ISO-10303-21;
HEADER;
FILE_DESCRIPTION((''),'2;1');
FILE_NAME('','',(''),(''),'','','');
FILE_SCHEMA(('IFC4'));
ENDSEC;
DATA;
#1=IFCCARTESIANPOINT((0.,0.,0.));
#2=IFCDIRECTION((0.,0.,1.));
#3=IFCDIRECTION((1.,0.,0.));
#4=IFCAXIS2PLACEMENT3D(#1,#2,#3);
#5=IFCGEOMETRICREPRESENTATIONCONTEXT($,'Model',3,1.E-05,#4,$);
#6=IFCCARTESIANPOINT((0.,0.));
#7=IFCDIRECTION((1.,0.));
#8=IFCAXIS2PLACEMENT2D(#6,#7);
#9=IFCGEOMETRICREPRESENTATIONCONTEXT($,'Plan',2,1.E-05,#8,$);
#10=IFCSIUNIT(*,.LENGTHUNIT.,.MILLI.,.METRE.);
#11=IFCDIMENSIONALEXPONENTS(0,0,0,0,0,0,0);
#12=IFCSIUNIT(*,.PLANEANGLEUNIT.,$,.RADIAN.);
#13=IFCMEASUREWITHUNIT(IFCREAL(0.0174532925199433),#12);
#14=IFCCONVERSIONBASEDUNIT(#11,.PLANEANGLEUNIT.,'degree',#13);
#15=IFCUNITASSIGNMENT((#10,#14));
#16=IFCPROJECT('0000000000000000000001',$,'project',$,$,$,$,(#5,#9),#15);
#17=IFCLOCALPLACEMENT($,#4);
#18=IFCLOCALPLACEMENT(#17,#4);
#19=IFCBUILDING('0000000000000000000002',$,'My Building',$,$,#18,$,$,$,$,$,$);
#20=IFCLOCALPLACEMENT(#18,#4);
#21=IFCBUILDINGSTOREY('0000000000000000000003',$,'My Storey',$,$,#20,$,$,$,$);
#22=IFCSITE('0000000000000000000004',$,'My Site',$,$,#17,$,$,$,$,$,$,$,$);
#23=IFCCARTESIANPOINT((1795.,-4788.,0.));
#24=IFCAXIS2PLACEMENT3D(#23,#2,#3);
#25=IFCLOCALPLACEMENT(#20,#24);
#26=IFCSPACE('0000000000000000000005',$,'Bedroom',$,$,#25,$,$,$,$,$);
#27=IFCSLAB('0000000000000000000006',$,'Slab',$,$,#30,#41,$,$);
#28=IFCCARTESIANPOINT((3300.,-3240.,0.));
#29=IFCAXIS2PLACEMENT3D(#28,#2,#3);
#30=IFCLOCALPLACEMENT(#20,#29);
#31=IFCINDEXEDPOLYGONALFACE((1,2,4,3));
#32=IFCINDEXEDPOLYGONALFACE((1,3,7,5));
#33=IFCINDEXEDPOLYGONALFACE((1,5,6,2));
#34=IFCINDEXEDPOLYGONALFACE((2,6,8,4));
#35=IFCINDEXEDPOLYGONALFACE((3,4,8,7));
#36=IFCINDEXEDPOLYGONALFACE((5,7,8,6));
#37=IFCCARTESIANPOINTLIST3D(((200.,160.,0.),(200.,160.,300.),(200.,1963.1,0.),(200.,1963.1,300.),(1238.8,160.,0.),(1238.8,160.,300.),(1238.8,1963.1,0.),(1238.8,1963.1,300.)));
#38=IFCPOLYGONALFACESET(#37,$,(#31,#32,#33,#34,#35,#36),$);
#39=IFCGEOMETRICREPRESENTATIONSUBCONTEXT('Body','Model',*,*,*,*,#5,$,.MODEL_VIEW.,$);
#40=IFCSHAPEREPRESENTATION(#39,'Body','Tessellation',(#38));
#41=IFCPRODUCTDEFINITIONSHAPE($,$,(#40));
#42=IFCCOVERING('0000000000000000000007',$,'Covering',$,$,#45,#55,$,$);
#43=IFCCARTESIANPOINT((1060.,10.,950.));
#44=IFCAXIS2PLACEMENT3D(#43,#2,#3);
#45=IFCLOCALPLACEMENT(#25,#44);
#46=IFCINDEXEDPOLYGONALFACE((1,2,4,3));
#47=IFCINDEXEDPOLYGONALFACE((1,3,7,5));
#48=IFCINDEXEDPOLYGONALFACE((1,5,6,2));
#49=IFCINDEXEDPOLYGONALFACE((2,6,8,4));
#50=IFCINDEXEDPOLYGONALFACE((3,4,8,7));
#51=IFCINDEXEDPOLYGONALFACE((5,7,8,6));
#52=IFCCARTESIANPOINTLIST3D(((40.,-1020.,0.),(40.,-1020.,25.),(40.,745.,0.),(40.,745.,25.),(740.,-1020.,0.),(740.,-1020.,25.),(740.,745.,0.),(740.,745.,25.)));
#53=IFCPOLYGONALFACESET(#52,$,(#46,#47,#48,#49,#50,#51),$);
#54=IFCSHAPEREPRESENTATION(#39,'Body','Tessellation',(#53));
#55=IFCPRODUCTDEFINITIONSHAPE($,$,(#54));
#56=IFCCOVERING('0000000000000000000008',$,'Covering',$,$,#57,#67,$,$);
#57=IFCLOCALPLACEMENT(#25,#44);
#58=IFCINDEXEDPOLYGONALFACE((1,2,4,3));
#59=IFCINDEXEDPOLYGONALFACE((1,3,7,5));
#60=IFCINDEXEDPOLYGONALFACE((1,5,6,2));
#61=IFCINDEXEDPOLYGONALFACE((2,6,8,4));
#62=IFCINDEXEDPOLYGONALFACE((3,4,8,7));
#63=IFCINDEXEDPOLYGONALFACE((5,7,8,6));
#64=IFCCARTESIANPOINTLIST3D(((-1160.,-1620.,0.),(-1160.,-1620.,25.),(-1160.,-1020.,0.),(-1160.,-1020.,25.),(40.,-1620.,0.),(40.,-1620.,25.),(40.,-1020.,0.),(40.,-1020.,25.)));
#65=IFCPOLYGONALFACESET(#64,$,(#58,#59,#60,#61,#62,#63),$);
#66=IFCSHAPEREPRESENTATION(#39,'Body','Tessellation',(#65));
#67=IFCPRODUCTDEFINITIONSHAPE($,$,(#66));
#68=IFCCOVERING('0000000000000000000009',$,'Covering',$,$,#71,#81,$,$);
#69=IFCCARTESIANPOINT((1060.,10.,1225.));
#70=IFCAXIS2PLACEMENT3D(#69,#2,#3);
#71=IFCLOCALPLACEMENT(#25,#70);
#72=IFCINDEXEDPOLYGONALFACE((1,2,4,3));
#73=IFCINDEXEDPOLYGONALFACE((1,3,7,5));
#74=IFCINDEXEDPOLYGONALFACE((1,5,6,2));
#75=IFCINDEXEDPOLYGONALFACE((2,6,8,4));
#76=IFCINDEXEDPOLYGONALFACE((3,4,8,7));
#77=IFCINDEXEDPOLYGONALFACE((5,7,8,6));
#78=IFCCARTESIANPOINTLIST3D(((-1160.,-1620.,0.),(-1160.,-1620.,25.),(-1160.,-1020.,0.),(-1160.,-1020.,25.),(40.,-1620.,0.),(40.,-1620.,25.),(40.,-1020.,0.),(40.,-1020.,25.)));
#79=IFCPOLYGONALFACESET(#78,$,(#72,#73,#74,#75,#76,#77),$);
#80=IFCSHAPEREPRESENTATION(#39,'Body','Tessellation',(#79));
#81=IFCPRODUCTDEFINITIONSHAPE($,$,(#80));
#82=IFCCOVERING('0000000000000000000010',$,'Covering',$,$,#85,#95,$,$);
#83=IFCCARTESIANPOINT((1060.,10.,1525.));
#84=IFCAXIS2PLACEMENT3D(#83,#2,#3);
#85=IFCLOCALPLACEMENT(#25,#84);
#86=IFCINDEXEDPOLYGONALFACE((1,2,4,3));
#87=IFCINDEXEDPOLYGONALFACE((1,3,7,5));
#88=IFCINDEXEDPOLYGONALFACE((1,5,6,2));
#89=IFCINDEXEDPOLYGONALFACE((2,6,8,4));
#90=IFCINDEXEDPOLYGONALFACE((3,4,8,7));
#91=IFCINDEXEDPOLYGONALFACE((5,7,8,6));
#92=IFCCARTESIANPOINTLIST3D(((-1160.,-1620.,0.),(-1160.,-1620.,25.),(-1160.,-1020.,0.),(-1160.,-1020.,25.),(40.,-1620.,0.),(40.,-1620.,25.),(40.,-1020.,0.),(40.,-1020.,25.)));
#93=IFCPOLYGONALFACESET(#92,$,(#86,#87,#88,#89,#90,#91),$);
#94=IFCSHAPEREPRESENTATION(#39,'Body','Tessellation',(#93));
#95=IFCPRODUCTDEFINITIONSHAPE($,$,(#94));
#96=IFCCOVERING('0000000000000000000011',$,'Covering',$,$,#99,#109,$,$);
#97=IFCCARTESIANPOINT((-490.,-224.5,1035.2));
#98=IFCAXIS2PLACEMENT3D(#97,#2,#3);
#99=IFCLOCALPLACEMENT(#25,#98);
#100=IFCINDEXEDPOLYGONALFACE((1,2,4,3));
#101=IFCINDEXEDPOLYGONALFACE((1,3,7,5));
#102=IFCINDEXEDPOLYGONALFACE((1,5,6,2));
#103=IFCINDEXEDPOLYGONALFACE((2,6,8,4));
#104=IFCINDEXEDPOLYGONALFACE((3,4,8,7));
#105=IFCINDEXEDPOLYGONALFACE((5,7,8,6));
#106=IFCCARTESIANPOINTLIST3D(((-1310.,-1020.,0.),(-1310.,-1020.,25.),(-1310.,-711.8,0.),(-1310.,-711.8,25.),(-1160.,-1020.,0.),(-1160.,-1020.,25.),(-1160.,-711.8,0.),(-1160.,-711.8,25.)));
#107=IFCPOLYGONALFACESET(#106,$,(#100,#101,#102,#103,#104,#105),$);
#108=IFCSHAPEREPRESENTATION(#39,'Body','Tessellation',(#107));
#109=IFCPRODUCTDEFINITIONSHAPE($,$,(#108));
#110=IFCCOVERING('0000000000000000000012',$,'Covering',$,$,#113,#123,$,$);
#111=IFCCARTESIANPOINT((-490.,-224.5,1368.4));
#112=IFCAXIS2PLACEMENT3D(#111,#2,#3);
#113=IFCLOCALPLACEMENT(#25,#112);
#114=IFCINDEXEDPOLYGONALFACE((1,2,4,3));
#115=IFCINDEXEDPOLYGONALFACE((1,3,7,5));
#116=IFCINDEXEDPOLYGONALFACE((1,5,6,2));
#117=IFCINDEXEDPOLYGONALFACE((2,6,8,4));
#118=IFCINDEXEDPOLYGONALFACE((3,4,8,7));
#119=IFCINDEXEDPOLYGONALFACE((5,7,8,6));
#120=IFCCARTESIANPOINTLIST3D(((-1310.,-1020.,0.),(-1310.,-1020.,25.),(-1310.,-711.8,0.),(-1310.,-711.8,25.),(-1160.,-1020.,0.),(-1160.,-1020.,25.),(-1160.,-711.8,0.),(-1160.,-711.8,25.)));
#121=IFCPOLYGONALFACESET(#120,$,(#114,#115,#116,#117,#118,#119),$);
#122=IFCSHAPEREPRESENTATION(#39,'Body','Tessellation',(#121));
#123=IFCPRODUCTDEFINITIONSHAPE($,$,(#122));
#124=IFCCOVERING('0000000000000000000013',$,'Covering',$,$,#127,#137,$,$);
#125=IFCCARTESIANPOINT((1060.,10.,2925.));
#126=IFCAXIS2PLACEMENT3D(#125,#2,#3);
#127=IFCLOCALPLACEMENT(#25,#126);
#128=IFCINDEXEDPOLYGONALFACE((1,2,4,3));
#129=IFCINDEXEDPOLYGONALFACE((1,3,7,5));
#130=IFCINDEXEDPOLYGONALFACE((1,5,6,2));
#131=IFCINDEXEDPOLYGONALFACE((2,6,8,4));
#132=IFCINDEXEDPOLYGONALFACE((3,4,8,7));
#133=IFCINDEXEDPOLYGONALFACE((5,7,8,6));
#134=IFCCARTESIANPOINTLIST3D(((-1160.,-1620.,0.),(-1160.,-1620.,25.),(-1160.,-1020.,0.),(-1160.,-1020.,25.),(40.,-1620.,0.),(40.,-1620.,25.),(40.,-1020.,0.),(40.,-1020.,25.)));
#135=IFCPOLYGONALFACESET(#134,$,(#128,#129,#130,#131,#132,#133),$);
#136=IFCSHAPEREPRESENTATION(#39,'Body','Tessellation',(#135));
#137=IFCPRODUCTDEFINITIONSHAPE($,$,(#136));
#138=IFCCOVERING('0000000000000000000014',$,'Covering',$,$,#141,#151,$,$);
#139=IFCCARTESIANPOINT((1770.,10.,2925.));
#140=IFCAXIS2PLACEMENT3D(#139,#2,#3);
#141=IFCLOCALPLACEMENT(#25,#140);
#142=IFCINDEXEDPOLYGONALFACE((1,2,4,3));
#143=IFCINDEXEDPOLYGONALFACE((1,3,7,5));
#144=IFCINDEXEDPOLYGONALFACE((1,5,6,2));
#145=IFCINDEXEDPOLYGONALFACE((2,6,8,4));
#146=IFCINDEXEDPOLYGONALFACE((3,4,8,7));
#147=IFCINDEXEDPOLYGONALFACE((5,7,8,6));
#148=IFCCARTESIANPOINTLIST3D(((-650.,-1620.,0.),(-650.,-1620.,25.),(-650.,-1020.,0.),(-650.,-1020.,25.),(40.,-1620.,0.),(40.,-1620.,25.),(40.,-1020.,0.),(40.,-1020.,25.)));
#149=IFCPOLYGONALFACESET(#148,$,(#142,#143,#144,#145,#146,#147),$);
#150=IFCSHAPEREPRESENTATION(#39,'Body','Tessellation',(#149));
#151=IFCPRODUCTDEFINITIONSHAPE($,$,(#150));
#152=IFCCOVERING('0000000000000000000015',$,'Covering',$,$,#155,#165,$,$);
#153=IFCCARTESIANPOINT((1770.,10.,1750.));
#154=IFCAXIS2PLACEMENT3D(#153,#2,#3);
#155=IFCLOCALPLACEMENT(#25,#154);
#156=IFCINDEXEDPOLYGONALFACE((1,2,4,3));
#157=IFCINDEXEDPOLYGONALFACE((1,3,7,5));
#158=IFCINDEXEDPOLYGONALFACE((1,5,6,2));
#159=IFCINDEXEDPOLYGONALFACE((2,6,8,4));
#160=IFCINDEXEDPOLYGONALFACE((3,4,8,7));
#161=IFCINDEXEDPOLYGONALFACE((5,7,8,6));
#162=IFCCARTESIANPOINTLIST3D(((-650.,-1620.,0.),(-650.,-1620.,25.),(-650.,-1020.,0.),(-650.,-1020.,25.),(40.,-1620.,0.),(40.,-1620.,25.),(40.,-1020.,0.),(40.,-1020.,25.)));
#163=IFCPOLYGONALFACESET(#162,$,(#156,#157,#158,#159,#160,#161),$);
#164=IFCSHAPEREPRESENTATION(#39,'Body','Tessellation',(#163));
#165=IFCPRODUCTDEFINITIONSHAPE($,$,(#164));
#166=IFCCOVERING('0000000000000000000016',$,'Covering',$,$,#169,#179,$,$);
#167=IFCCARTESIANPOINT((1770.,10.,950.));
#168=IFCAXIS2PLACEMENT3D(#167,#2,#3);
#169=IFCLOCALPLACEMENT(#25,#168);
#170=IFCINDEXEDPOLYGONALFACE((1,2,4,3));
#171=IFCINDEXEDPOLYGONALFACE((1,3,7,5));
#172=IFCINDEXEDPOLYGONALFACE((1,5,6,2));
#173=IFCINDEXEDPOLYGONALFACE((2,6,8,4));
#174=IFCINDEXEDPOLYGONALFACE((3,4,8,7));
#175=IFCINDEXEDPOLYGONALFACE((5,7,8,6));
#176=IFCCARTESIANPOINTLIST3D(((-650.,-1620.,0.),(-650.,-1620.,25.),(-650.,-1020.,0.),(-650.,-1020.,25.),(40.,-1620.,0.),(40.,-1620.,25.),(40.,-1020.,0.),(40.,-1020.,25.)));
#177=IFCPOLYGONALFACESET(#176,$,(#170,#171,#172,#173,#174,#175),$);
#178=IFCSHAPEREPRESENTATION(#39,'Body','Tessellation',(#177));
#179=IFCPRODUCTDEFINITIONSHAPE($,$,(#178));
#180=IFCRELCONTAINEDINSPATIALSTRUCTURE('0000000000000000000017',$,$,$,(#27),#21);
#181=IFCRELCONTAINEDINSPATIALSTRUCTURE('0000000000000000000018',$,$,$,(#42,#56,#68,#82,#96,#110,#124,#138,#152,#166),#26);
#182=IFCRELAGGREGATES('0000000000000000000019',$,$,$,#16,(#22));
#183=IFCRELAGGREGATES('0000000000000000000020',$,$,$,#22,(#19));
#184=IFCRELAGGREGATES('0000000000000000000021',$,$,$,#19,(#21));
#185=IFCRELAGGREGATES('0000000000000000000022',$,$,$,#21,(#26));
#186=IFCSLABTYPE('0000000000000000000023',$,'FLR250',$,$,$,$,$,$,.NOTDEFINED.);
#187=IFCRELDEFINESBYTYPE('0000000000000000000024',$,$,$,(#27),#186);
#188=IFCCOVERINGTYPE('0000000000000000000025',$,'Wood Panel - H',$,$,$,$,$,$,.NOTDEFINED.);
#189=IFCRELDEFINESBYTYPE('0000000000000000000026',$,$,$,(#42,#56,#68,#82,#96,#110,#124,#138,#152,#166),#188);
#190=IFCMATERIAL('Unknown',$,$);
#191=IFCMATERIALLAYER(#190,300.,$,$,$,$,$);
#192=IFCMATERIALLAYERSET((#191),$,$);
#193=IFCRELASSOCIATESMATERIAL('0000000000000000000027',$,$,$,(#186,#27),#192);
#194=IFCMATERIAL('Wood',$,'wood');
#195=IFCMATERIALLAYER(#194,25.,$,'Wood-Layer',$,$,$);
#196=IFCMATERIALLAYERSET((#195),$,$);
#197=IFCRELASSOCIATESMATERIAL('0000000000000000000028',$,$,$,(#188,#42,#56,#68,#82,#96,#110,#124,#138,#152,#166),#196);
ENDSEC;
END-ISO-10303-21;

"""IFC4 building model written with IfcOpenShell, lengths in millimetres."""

from ifc_helpers import new_model, entity, si_unit, converted_unit, frame, origin_with_axes, origin_2d_with_axis, place, context, subcontext, project, spatial, line, indexed_curve, outline, extrude, material, layer, layer_set, layer_usage, type_object, element, save


model = new_model("IFC4")

# Units and contexts
model_context = context("Model", 3, precision=1e-05, world=origin_with_axes())
plan_context = context("Plan", 2, precision=1e-05, world=origin_2d_with_axis())
body_context_1 = subcontext(model_context, "Body", "Model", "MODEL_VIEW")
ifc_project = project(units=[si_unit("LENGTHUNIT", "METRE", prefix="MILLI"), converted_unit("PLANEANGLEUNIT", "degree", entity("IfcReal", 0.0174532925199433), si_unit("PLANEANGLEUNIT", "RADIAN"), dimensions=[0, 0, 0, 0, 0, 0, 0])], contexts=[model_context, plan_context])

# Site, building, storey
site_placement = place(None, origin_with_axes())
site = spatial("IfcSite", under=ifc_project, at=site_placement, Name="My Site")
building_placement = place(site_placement, origin_with_axes())
building = spatial("IfcBuilding", under=site, at=building_placement, Name="My Building")
storey_placement = place(building_placement, origin_with_axes())
storey = spatial("IfcBuildingStorey", under=building, at=storey_placement, Name="My Storey")

# Slab
ifc_material_1 = material(Name="Unknown")
ifc_layer_1 = layer(ifc_material_1, 300.0)
ifc_layer_set_1 = layer_set([ifc_layer_1])
ifc_layer_usage_1 = layer_usage(ifc_layer_set_1, "AXIS3", "POSITIVE", 0.0)
slab_type = type_object("IfcSlabType", Name="FLR250", PredefinedType="NOTDEFINED", material=ifc_layer_set_1)
slab_placement = place(storey_placement, frame((3300.0, -3240.0, 0.0), z_axis=(0.0, 0.0, 1.0), x_axis=(1.0, 0.0, 0.0)))
element("IfcSlab", 1, at=slab_placement, inside=storey, type_object=slab_type, material=ifc_layer_usage_1, Name="Slab", context=body_context_1, shape_type="SweptSolid", body=[
    extrude(outline(indexed_curve([(200.0, 160.0), (1238.8, 160.0), (1238.8, 1963.1), (200.0, 1963.1)], segments=[line(4, 1), line(1, 2), line(2, 3), line(3, 4)], self_intersect=False)), None, (0.0, 0.0, 1.0), 300.0),
])

# Shared definitions
space_1_placement = place(storey_placement, frame((1795.0, -4788.0, 0.0), z_axis=(0.0, 0.0, 1.0), x_axis=(1.0, 0.0, 0.0)))
space_1 = spatial("IfcSpace", under=storey, at=space_1_placement, Name="Bedroom")

# Coverings
ifc_material_2 = material(Name="Wood", Category="wood")
ifc_layer_2 = layer(ifc_material_2, 25.0, Name="Wood-Layer")
ifc_layer_set_2 = layer_set([ifc_layer_2])
ifc_layer_usage_2 = layer_usage(ifc_layer_set_2, "AXIS3", "POSITIVE", 0.0)
covering_type_1 = type_object("IfcCoveringType", Name="Wood Panel - H", PredefinedType="NOTDEFINED", material=ifc_layer_set_2)
covering_1_placement = place(space_1_placement, frame((1060.0, 10.0, 950.0), z_axis=(0.0, 0.0, 1.0), x_axis=(1.0, 0.0, 0.0)))
element("IfcCovering", 2, at=covering_1_placement, inside=space_1, type_object=covering_type_1, material=ifc_layer_usage_2, Name="Covering", context=body_context_1, shape_type="SweptSolid", body=[
    extrude(outline(indexed_curve([(740.0, -1020.0), (740.0, 745.0), (40.0, 745.0), (40.0, -1020.0)], segments=[line(3, 2), line(2, 1), line(1, 4), line(4, 3)], self_intersect=False)), None, (0.0, 0.0, 1.0), 25.0),
])
ifc_layer_usage_3 = layer_usage(ifc_layer_set_2, "AXIS3", "POSITIVE", 0.0)
covering_2_placement = place(space_1_placement, frame((1060.0, 10.0, 950.0), z_axis=(0.0, 0.0, 1.0), x_axis=(1.0, 0.0, 0.0)))
element("IfcCovering", 3, at=covering_2_placement, inside=space_1, type_object=covering_type_1, material=ifc_layer_usage_3, Name="Covering", context=body_context_1, shape_type="SweptSolid", body=[
    extrude(outline(indexed_curve([(40.0, -1620.0), (40.0, -1020.0), (-1160.0, -1020.0), (-1160.0, -1620.0)], segments=[line(3, 2), line(2, 1), line(1, 4), line(4, 3)], self_intersect=False)), None, (0.0, 0.0, 1.0), 25.0),
])
ifc_layer_usage_4 = layer_usage(ifc_layer_set_2, "AXIS3", "POSITIVE", 0.0)
covering_3_placement = place(space_1_placement, frame((1060.0, 10.0, 1225.0), z_axis=(0.0, 0.0, 1.0), x_axis=(1.0, 0.0, 0.0)))
element("IfcCovering", 4, at=covering_3_placement, inside=space_1, type_object=covering_type_1, material=ifc_layer_usage_4, Name="Covering", context=body_context_1, shape_type="SweptSolid", body=[
    extrude(outline(indexed_curve([(40.0, -1620.0), (40.0, -1020.0), (-1160.0, -1020.0), (-1160.0, -1620.0)], segments=[line(3, 2), line(2, 1), line(1, 4), line(4, 3)], self_intersect=False)), None, (0.0, 0.0, 1.0), 25.0),
])
ifc_layer_usage_5 = layer_usage(ifc_layer_set_2, "AXIS3", "POSITIVE", 0.0)
covering_4_placement = place(space_1_placement, frame((1060.0, 10.0, 1525.0), z_axis=(0.0, 0.0, 1.0), x_axis=(1.0, 0.0, 0.0)))
element("IfcCovering", 5, at=covering_4_placement, inside=space_1, type_object=covering_type_1, material=ifc_layer_usage_5, Name="Covering", context=body_context_1, shape_type="SweptSolid", body=[
    extrude(outline(indexed_curve([(40.0, -1620.0), (40.0, -1020.0), (-1160.0, -1020.0), (-1160.0, -1620.0)], segments=[line(3, 2), line(2, 1), line(1, 4), line(4, 3)], self_intersect=False)), None, (0.0, 0.0, 1.0), 25.0),
])
ifc_layer_usage_6 = layer_usage(ifc_layer_set_2, "AXIS3", "POSITIVE", 0.0)
covering_5_placement = place(space_1_placement, frame((-490.0, -224.5, 1035.2), z_axis=(0.0, 0.0, 1.0), x_axis=(1.0, 0.0, 0.0)))
element("IfcCovering", 6, at=covering_5_placement, inside=space_1, type_object=covering_type_1, material=ifc_layer_usage_6, Name="Covering", context=body_context_1, shape_type="SweptSolid", body=[
    extrude(outline(indexed_curve([(-1310.0, -1020.0), (-1310.0, -711.8), (-1160.0, -711.8), (-1160.0, -1020.0)], segments=[line(4, 1), line(1, 2), line(2, 3), line(3, 4)], self_intersect=False)), None, (0.0, 0.0, 1.0), 25.0),
])
ifc_layer_usage_7 = layer_usage(ifc_layer_set_2, "AXIS3", "POSITIVE", 0.0)
covering_6_placement = place(space_1_placement, frame((-490.0, -224.5, 1368.4), z_axis=(0.0, 0.0, 1.0), x_axis=(1.0, 0.0, 0.0)))
element("IfcCovering", 7, at=covering_6_placement, inside=space_1, type_object=covering_type_1, material=ifc_layer_usage_7, Name="Covering", context=body_context_1, shape_type="SweptSolid", body=[
    extrude(outline(indexed_curve([(-1310.0, -1020.0), (-1310.0, -711.8), (-1160.0, -711.8), (-1160.0, -1020.0)], segments=[line(4, 1), line(1, 2), line(2, 3), line(3, 4)], self_intersect=False)), None, (0.0, 0.0, 1.0), 25.0),
])
ifc_layer_usage_8 = layer_usage(ifc_layer_set_2, "AXIS3", "POSITIVE", 0.0)
covering_7_placement = place(space_1_placement, frame((1060.0, 10.0, 2925.0), z_axis=(0.0, 0.0, 1.0), x_axis=(1.0, 0.0, 0.0)))
element("IfcCovering", 8, at=covering_7_placement, inside=space_1, type_object=covering_type_1, material=ifc_layer_usage_8, Name="Covering", context=body_context_1, shape_type="SweptSolid", body=[
    extrude(outline(indexed_curve([(-1160.0, -1020.0), (40.0, -1020.0), (40.0, -1620.0), (-1160.0, -1620.0)], segments=[line(4, 1), line(1, 2), line(2, 3), line(3, 4)], self_intersect=False)), None, (0.0, 0.0, 1.0), 25.0),
])
ifc_layer_usage_9 = layer_usage(ifc_layer_set_2, "AXIS3", "POSITIVE", 0.0)
covering_8_placement = place(space_1_placement, frame((1770.0, 10.0, 2925.0), z_axis=(0.0, 0.0, 1.0), x_axis=(1.0, 0.0, 0.0)))
element("IfcCovering", 9, at=covering_8_placement, inside=space_1, type_object=covering_type_1, material=ifc_layer_usage_9, Name="Covering", context=body_context_1, shape_type="SweptSolid", body=[
    extrude(outline(indexed_curve([(40.0, -1620.0), (40.0, -1020.0), (-650.0, -1020.0), (-650.0, -1620.0)], segments=[line(3, 2), line(2, 1), line(1, 4), line(4, 3)], self_intersect=False)), None, (0.0, 0.0, 1.0), 25.0),
])
ifc_layer_usage_10 = layer_usage(ifc_layer_set_2, "AXIS3", "POSITIVE", 0.0)
covering_9_placement = place(space_1_placement, frame((1770.0, 10.0, 1750.0), z_axis=(0.0, 0.0, 1.0), x_axis=(1.0, 0.0, 0.0)))
element("IfcCovering", 10, at=covering_9_placement, inside=space_1, type_object=covering_type_1, material=ifc_layer_usage_10, Name="Covering", context=body_context_1, shape_type="SweptSolid", body=[
    extrude(outline(indexed_curve([(40.0, -1620.0), (40.0, -1020.0), (-650.0, -1020.0), (-650.0, -1620.0)], segments=[line(3, 2), line(2, 1), line(1, 4), line(4, 3)], self_intersect=False)), None, (0.0, 0.0, 1.0), 25.0),
])
ifc_layer_usage_11 = layer_usage(ifc_layer_set_2, "AXIS3", "POSITIVE", 0.0)
covering_10_placement = place(space_1_placement, frame((1770.0, 10.0, 950.0), z_axis=(0.0, 0.0, 1.0), x_axis=(1.0, 0.0, 0.0)))
element("IfcCovering", 11, at=covering_10_placement, inside=space_1, type_object=covering_type_1, material=ifc_layer_usage_11, Name="Covering", context=body_context_1, shape_type="SweptSolid", body=[
    extrude(outline(indexed_curve([(40.0, -1620.0), (40.0, -1020.0), (-650.0, -1020.0), (-650.0, -1620.0)], segments=[line(3, 2), line(2, 1), line(1, 4), line(4, 3)], self_intersect=False)), None, (0.0, 0.0, 1.0), 25.0),
])

save(model, "model.ifc")
